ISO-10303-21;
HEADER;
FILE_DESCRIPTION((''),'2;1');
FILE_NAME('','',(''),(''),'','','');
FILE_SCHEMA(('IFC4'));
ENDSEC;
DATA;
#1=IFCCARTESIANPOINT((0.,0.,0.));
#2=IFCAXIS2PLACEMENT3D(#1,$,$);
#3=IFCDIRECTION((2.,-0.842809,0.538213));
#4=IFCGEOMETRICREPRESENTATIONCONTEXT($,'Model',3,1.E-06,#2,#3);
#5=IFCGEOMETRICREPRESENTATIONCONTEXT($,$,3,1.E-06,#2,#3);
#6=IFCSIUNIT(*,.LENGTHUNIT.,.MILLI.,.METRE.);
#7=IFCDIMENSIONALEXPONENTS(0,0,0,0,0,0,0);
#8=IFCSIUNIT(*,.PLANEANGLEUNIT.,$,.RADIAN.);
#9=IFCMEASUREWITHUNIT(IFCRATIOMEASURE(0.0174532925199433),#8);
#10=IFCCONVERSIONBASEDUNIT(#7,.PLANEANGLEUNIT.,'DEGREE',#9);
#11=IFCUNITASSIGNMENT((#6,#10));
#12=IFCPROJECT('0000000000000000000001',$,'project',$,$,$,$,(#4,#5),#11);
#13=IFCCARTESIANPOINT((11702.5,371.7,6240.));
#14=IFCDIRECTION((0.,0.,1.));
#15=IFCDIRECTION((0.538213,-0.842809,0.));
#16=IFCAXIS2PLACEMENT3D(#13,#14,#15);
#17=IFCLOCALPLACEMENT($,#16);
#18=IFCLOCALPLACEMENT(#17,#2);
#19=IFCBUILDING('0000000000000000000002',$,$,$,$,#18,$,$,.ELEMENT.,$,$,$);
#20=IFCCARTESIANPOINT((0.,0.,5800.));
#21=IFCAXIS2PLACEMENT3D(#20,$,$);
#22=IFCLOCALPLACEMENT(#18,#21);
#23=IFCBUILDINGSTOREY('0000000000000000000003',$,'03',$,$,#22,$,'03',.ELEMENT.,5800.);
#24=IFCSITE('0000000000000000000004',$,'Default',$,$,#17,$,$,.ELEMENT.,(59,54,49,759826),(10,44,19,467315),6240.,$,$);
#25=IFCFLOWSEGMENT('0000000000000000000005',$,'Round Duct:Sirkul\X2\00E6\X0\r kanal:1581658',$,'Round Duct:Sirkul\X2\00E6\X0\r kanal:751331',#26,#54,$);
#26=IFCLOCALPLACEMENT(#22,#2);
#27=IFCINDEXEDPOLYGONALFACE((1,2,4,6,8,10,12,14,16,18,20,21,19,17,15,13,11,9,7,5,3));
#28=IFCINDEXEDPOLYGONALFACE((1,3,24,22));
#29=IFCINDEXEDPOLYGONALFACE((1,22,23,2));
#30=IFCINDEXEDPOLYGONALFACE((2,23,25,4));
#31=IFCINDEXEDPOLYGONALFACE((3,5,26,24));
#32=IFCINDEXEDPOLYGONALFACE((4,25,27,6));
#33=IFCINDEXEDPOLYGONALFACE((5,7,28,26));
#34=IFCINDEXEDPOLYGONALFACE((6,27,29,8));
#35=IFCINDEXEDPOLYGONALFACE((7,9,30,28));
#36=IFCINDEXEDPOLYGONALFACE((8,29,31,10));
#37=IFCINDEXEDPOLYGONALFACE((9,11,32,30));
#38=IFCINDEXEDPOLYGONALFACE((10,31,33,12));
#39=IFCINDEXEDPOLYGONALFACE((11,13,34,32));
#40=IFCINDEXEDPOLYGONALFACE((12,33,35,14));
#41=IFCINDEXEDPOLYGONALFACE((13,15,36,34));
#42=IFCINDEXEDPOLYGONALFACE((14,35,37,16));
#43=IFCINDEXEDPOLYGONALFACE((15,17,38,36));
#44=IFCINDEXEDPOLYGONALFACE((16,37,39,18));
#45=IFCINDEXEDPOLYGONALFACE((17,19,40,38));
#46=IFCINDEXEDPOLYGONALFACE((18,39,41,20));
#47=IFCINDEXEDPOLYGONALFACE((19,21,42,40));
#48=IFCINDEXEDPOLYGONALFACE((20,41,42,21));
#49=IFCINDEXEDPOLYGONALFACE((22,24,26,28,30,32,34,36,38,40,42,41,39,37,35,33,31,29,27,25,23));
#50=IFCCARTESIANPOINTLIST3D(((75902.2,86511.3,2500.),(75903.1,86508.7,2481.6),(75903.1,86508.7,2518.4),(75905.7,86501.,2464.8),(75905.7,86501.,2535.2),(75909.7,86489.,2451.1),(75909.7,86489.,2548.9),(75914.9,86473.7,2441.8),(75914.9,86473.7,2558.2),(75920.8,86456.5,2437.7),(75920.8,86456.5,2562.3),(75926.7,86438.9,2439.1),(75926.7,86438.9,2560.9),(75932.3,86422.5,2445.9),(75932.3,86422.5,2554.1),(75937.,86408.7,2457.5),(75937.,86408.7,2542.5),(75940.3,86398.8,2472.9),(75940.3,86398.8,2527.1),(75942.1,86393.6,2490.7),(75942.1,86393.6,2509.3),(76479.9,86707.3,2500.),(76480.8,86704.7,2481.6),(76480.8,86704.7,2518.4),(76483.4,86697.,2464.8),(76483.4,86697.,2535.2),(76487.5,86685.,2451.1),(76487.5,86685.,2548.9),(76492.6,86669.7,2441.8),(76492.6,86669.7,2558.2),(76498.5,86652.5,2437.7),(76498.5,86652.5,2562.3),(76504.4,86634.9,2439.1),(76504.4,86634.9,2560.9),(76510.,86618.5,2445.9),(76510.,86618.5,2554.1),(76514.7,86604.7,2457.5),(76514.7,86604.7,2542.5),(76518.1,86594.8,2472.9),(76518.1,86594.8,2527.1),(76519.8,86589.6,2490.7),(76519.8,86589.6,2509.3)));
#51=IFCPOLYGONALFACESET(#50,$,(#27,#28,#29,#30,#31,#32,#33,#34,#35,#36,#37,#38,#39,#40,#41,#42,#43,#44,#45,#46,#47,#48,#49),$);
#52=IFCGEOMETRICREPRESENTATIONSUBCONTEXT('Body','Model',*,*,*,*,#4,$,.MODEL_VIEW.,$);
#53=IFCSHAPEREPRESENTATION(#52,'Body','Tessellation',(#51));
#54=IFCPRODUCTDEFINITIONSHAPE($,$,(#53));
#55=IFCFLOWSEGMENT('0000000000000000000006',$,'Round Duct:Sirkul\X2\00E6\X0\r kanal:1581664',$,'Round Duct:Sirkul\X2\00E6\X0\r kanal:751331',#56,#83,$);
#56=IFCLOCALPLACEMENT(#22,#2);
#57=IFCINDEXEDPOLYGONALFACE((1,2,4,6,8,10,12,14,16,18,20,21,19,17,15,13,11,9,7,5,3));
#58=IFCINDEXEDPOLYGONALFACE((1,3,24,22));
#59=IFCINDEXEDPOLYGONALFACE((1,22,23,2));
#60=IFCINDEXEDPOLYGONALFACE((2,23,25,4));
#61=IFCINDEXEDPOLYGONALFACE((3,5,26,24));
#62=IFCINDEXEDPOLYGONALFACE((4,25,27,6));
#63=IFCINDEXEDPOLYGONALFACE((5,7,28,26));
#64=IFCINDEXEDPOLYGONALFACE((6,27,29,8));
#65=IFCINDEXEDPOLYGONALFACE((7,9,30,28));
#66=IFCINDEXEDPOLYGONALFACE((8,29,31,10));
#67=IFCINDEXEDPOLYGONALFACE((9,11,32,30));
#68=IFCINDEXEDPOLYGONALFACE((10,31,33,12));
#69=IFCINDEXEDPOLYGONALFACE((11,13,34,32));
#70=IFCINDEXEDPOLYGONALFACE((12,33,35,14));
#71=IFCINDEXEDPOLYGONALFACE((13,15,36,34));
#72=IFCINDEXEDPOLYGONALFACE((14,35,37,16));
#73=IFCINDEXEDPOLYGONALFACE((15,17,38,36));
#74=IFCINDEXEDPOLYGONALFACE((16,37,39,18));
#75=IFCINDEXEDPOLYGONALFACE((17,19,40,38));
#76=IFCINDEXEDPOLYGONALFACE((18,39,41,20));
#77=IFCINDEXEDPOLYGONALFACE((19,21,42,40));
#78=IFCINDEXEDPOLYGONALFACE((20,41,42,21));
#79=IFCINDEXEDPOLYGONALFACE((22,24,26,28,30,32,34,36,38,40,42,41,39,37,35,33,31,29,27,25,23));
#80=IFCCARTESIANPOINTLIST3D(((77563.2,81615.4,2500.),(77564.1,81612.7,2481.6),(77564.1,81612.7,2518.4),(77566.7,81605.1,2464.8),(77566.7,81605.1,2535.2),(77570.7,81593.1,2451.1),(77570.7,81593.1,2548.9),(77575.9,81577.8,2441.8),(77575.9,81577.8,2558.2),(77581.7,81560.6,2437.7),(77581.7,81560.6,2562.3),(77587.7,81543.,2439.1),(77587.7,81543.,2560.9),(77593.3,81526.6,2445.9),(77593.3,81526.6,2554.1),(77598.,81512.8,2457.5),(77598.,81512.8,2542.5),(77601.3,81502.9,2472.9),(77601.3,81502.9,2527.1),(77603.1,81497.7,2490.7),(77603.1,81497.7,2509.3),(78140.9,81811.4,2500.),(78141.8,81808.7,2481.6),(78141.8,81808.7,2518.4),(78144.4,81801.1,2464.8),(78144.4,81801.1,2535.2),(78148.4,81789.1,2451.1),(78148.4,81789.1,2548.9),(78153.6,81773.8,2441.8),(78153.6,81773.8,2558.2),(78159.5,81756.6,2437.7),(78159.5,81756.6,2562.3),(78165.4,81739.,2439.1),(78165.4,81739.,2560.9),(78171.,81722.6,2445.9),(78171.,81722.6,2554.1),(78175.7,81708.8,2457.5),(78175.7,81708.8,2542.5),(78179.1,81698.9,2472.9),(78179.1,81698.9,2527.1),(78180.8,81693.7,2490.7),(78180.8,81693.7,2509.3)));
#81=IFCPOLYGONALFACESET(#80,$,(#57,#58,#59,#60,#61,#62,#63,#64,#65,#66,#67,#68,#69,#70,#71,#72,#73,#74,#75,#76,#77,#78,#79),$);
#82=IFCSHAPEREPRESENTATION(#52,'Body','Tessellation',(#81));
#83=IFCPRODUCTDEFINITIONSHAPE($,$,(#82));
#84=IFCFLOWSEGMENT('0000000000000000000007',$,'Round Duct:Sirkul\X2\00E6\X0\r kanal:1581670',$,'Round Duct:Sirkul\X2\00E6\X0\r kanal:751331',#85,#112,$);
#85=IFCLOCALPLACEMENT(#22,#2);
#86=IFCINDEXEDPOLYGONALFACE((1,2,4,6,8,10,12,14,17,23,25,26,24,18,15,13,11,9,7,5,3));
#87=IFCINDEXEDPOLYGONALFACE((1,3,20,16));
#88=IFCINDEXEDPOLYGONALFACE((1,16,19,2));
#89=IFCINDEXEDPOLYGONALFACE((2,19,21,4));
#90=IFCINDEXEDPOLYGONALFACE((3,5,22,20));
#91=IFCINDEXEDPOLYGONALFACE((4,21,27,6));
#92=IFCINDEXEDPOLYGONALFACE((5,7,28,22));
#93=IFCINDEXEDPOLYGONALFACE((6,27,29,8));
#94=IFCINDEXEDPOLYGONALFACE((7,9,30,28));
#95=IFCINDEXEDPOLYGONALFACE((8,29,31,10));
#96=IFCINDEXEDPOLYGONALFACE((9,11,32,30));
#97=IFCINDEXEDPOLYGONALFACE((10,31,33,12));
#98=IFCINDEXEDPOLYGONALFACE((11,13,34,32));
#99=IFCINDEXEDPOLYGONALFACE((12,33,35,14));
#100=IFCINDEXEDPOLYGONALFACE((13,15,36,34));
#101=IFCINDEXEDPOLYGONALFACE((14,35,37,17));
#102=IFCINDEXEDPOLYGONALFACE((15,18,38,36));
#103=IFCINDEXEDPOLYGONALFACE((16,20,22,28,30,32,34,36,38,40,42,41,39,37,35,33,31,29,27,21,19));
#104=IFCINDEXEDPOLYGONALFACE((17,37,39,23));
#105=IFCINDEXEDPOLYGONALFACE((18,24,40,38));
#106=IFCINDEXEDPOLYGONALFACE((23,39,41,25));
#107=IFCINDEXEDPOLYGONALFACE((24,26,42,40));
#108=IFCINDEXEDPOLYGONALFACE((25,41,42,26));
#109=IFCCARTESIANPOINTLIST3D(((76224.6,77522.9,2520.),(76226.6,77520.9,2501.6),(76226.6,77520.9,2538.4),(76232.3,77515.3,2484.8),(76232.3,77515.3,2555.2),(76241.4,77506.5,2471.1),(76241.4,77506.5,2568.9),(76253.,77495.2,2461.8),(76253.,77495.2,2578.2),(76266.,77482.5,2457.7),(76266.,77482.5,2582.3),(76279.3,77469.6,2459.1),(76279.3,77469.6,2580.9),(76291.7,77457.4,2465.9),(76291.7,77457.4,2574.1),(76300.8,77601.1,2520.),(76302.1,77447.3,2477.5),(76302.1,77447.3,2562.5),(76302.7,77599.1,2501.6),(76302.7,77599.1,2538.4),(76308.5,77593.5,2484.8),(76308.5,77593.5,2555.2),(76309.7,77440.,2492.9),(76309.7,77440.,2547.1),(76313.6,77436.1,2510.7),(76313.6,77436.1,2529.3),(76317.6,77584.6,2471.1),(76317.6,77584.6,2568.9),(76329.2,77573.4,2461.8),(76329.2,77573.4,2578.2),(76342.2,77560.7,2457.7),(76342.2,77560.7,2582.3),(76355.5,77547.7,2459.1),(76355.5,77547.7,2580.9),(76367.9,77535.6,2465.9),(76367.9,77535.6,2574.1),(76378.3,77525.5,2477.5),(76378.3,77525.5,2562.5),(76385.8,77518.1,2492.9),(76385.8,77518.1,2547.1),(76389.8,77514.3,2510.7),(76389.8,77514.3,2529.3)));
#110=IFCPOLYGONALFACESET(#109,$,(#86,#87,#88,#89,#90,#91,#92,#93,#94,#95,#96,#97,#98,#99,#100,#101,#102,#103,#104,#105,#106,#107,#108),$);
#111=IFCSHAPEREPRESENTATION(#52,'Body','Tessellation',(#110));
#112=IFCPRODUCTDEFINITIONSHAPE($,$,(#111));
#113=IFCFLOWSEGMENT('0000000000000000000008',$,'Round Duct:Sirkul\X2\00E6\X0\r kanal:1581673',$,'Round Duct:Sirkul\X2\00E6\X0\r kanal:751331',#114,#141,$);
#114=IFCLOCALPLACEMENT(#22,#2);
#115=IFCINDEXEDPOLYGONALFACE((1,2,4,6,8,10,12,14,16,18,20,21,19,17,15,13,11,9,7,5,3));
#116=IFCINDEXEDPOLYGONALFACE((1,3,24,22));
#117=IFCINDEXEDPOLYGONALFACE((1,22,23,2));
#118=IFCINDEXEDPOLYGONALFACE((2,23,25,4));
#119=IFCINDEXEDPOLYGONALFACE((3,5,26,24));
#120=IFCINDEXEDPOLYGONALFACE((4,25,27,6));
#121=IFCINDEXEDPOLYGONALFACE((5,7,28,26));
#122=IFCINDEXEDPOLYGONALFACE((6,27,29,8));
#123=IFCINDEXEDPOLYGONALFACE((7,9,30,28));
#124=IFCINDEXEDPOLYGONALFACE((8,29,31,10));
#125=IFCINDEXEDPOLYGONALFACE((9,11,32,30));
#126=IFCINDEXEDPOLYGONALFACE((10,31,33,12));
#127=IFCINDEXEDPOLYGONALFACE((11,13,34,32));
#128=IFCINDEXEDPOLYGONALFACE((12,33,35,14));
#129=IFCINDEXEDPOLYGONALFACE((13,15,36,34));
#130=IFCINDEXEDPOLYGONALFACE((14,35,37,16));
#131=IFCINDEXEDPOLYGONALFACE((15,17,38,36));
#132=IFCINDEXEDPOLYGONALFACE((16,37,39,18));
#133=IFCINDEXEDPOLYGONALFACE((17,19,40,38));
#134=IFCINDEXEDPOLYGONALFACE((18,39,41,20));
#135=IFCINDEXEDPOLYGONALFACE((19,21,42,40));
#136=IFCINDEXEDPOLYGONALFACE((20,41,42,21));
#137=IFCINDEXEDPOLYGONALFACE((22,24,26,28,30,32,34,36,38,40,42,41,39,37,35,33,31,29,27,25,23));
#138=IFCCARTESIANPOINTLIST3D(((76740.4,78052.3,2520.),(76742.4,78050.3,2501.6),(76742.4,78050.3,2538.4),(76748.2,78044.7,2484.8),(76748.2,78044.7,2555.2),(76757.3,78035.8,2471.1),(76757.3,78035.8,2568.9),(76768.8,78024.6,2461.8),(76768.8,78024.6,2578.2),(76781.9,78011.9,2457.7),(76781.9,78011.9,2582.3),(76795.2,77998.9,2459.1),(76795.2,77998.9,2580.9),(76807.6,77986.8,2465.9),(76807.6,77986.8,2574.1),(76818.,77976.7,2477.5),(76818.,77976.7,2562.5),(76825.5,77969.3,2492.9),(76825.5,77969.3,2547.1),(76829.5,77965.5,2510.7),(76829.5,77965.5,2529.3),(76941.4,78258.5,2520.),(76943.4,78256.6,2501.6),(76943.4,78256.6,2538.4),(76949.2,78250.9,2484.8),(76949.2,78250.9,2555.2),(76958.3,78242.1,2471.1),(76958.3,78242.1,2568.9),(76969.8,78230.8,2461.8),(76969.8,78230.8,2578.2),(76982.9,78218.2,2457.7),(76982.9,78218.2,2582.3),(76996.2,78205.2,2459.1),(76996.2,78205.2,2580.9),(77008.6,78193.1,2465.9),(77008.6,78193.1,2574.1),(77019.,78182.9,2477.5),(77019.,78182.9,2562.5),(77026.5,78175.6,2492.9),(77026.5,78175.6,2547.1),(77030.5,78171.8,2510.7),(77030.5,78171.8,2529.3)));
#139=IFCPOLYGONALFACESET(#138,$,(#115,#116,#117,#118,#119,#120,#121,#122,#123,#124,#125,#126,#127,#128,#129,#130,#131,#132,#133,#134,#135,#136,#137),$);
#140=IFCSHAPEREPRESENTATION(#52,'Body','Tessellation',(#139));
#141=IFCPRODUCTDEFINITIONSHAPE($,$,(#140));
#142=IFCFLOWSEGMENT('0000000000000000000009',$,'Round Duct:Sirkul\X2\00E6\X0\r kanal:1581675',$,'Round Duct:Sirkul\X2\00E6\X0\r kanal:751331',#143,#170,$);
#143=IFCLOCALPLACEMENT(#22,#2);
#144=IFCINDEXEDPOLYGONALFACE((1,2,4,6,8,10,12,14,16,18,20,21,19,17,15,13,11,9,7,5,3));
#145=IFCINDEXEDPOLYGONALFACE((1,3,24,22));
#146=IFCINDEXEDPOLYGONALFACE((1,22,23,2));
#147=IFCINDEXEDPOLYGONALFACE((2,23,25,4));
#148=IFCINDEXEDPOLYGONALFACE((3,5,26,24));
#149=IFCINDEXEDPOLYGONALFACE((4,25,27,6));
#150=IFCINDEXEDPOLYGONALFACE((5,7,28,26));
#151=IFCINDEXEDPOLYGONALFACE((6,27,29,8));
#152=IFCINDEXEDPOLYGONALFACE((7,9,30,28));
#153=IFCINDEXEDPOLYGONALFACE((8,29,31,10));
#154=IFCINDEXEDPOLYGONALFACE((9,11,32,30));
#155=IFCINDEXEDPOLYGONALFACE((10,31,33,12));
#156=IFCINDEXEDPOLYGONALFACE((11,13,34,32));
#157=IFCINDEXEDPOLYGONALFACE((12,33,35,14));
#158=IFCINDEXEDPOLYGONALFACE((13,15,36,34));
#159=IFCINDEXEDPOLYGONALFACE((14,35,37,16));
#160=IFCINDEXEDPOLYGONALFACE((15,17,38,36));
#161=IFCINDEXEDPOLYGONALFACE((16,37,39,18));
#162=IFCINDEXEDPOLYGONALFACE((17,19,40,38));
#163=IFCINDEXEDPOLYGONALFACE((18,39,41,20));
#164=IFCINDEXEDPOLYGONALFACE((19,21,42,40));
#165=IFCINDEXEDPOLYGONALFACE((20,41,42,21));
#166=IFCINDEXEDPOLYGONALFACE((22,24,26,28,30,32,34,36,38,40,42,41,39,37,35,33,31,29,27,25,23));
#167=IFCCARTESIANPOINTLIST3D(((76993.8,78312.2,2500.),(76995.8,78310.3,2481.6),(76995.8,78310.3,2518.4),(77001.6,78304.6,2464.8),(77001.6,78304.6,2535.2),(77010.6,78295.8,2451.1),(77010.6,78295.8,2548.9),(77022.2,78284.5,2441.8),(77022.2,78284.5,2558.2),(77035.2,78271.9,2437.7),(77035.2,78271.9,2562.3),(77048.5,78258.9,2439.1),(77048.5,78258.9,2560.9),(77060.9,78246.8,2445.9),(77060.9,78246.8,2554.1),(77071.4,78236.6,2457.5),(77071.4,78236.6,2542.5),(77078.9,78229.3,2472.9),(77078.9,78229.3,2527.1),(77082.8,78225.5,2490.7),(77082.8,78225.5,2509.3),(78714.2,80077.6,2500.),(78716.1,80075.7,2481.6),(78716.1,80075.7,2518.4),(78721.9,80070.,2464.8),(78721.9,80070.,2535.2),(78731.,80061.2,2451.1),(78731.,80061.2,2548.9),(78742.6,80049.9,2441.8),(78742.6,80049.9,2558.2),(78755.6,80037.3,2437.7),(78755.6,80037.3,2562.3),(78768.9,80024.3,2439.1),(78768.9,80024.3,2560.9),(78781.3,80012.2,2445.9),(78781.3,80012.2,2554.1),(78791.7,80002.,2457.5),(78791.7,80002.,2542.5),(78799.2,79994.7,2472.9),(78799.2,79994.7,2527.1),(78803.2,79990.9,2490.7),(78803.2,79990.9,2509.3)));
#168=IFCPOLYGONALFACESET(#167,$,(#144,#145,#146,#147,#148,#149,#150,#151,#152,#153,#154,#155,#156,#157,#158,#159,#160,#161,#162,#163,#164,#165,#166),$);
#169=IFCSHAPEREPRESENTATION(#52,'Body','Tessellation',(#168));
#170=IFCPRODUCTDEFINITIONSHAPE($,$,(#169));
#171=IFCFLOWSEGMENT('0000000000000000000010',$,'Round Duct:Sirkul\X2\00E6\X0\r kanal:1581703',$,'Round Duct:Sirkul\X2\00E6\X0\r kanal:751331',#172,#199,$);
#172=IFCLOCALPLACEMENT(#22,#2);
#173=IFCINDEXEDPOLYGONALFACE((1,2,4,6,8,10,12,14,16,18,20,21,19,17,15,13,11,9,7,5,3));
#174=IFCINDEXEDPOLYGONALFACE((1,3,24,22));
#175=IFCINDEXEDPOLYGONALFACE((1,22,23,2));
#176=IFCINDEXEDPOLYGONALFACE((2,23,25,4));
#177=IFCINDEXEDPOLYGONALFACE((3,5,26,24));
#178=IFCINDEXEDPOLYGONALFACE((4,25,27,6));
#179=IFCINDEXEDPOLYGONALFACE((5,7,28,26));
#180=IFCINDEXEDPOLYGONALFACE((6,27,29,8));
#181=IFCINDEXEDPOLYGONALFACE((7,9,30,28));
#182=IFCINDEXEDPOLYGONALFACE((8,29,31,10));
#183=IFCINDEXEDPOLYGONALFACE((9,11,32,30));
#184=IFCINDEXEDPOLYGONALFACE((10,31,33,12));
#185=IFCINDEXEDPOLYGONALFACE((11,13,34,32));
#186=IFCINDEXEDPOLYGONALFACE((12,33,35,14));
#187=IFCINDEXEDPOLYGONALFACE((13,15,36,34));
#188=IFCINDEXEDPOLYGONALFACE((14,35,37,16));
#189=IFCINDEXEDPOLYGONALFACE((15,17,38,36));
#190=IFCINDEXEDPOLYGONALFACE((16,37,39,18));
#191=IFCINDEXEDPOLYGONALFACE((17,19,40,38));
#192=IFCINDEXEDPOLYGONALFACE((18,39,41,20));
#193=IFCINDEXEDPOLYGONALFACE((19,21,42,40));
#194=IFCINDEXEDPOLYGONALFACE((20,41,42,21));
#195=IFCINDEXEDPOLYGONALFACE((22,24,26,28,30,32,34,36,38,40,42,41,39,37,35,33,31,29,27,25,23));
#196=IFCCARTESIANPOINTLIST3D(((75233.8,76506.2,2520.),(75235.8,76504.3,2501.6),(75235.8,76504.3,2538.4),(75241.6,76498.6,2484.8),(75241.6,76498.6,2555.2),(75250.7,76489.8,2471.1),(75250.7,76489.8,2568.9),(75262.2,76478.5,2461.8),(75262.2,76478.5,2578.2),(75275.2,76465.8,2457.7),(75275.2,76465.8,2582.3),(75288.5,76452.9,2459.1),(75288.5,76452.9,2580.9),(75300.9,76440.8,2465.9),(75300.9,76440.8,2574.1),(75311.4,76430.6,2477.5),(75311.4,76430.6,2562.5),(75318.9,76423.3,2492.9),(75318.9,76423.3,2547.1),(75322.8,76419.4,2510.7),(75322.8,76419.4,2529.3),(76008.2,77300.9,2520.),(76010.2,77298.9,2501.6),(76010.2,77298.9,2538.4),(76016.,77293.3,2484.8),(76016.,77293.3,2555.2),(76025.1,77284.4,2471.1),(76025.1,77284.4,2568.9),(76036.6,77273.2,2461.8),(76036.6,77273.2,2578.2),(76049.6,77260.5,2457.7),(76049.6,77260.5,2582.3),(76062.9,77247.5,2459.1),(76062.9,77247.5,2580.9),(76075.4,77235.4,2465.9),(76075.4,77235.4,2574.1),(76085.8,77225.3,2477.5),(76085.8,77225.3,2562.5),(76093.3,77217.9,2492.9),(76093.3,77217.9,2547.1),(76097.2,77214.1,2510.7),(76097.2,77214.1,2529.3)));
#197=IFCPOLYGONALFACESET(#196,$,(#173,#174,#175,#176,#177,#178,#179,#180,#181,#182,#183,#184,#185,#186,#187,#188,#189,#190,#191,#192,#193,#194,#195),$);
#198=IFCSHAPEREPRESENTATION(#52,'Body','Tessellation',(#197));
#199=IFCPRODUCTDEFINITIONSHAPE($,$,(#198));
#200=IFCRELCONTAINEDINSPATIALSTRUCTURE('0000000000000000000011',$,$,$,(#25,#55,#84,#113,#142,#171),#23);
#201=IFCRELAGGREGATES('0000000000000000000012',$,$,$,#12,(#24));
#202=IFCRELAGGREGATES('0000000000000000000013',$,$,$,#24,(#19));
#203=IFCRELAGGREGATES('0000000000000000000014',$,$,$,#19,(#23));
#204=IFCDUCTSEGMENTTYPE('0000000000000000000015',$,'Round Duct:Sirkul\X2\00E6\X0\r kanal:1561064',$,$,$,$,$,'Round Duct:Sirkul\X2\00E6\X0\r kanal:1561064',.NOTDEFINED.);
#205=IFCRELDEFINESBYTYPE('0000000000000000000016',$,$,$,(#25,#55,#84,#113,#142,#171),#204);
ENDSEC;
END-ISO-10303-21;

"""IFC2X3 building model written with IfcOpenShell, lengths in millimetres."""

from ifc_helpers import new_model, entity, si_unit, converted_unit, direction, frame, frame_2d, origin, origin_2d_with_axis, place, context, subcontext, project, spatial, circle, extrude, type_object, element, save


model = new_model("IFC2X3")

# Units and contexts
model_context = context("Model", 3, precision=1e-06, world=origin(), true_north=direction((2.0, -0.842809, 0.538213)))
context_of_model = context(None, 3, precision=1e-06, world=origin(), true_north=direction((2.0, -0.842809, 0.538213)))
body_context = subcontext(model_context, "Body", "Model", "MODEL_VIEW")
ifc_project = project(units=[si_unit("LENGTHUNIT", "METRE", prefix="MILLI"), converted_unit("PLANEANGLEUNIT", "DEGREE", entity("IfcRatioMeasure", 0.0174532925199433), si_unit("PLANEANGLEUNIT", "RADIAN"), dimensions=[0, 0, 0, 0, 0, 0, 0])], contexts=[model_context, context_of_model])

# Site, building, storey
site_placement = place(None, frame((11702.5, 371.7, 6240.0), z_axis=(0.0, 0.0, 1.0), x_axis=(0.538213, -0.842809, 0.0)))
site = spatial("IfcSite", under=ifc_project, at=site_placement, Name="Default", CompositionType="ELEMENT", RefLatitude=(59, 54, 49, 759826), RefLongitude=(10, 44, 19, 467315), RefElevation=6240.0)
building_placement = place(site_placement, origin())
building = spatial("IfcBuilding", under=site, at=building_placement, CompositionType="ELEMENT")
storey_placement = place(building_placement, frame((0.0, 0.0, 5800.0)))
storey = spatial("IfcBuildingStorey", under=building, at=storey_placement, Name="03", LongName="03", CompositionType="ELEMENT", Elevation=5800.0)

# Flow segments
duct_segment_type = type_object("IfcDuctSegmentType", Name="Round Duct:Sirkulær kanal:1561064", ElementType="Round Duct:Sirkulær kanal:1561064", PredefinedType="NOTDEFINED")
flow_segment_1_placement = place(storey_placement, origin())
element("IfcFlowSegment", 1, at=flow_segment_1_placement, inside=storey, type_object=duct_segment_type, Name="Round Duct:Sirkulær kanal:1581658", ObjectType="Round Duct:Sirkulær kanal:751331", context=body_context, shape_type="SweptSolid", body=[
    extrude(circle(Radius=62.5, at=origin_2d_with_axis()), frame((75922.3, 86452.1, 2500.0), z_axis=(0.946986, 0.321274, 0.0), x_axis=(-0.321274, 0.946986, 0.0)), (0.0, 0.0, 1.0), 610.1),
])
flow_segment_2_placement = place(storey_placement, origin())
element("IfcFlowSegment", 2, at=flow_segment_2_placement, inside=storey, type_object=duct_segment_type, Name="Round Duct:Sirkulær kanal:1581664", ObjectType="Round Duct:Sirkulær kanal:751331", context=body_context, shape_type="SweptSolid", body=[
    extrude(circle(Radius=62.5, at=origin_2d_with_axis()), frame((77583.2, 81556.2, 2500.0), z_axis=(0.946986, 0.321274, 0.0), x_axis=(-0.321274, 0.946986, 0.0)), (0.0, 0.0, 1.0), 610.1),
])
flow_segment_3_placement = place(storey_placement, origin())
element("IfcFlowSegment", 3, at=flow_segment_3_placement, inside=storey, type_object=duct_segment_type, Name="Round Duct:Sirkulær kanal:1581670", ObjectType="Round Duct:Sirkulær kanal:751331", context=body_context, shape_type="SweptSolid", body=[
    extrude(circle(Radius=62.5, at=origin_2d_with_axis()), frame((76269.3, 77479.3, 2520.0), z_axis=(0.697915, 0.71618, 0.0), x_axis=(-0.71618, 0.697915, 0.0)), (0.0, 0.0, 1.0), 109.2),
])
flow_segment_4_placement = place(storey_placement, origin())
element("IfcFlowSegment", 4, at=flow_segment_4_placement, inside=storey, type_object=duct_segment_type, Name="Round Duct:Sirkulær kanal:1581673", ObjectType="Round Duct:Sirkulær kanal:751331", context=body_context, shape_type="SweptSolid", body=[
    extrude(circle(Radius=62.5, at=frame_2d((0.0, 0.0), x_axis=(1.0, 0.0))), frame((76785.2, 78008.6, 2520.0), z_axis=(0.697915, 0.71618, 0.0), x_axis=(-0.71618, 0.697915, 0.0)), (0.0, 0.0, 1.0), 288.0),
])
flow_segment_5_placement = place(storey_placement, origin())
element("IfcFlowSegment", 5, at=flow_segment_5_placement, inside=storey, type_object=duct_segment_type, Name="Round Duct:Sirkulær kanal:1581675", ObjectType="Round Duct:Sirkulær kanal:751331", context=body_context, shape_type="SweptSolid", body=[
    extrude(circle(Radius=62.5, at=frame_2d((0.0, 0.0), x_axis=(1.0, 0.0))), frame((77038.5, 78268.6, 2500.0), z_axis=(0.697915, 0.71618, 0.0), x_axis=(-0.71618, 0.697915, 0.0)), (0.0, 0.0, 1.0), 2465.0),
])
flow_segment_6_placement = place(storey_placement, origin())
element("IfcFlowSegment", 6, at=flow_segment_6_placement, inside=storey, type_object=duct_segment_type, Name="Round Duct:Sirkulær kanal:1581703", ObjectType="Round Duct:Sirkulær kanal:751331", context=body_context, shape_type="SweptSolid", body=[
    extrude(circle(Radius=62.5, at=frame_2d((0.0, 0.0), x_axis=(1.0, 0.0))), frame((75278.6, 76462.6, 2520.0), z_axis=(0.697915, 0.71618, 0.0), x_axis=(-0.71618, 0.697915, 0.0)), (0.0, 0.0, 1.0), 1109.6),
])

save(model, "model.ifc")
